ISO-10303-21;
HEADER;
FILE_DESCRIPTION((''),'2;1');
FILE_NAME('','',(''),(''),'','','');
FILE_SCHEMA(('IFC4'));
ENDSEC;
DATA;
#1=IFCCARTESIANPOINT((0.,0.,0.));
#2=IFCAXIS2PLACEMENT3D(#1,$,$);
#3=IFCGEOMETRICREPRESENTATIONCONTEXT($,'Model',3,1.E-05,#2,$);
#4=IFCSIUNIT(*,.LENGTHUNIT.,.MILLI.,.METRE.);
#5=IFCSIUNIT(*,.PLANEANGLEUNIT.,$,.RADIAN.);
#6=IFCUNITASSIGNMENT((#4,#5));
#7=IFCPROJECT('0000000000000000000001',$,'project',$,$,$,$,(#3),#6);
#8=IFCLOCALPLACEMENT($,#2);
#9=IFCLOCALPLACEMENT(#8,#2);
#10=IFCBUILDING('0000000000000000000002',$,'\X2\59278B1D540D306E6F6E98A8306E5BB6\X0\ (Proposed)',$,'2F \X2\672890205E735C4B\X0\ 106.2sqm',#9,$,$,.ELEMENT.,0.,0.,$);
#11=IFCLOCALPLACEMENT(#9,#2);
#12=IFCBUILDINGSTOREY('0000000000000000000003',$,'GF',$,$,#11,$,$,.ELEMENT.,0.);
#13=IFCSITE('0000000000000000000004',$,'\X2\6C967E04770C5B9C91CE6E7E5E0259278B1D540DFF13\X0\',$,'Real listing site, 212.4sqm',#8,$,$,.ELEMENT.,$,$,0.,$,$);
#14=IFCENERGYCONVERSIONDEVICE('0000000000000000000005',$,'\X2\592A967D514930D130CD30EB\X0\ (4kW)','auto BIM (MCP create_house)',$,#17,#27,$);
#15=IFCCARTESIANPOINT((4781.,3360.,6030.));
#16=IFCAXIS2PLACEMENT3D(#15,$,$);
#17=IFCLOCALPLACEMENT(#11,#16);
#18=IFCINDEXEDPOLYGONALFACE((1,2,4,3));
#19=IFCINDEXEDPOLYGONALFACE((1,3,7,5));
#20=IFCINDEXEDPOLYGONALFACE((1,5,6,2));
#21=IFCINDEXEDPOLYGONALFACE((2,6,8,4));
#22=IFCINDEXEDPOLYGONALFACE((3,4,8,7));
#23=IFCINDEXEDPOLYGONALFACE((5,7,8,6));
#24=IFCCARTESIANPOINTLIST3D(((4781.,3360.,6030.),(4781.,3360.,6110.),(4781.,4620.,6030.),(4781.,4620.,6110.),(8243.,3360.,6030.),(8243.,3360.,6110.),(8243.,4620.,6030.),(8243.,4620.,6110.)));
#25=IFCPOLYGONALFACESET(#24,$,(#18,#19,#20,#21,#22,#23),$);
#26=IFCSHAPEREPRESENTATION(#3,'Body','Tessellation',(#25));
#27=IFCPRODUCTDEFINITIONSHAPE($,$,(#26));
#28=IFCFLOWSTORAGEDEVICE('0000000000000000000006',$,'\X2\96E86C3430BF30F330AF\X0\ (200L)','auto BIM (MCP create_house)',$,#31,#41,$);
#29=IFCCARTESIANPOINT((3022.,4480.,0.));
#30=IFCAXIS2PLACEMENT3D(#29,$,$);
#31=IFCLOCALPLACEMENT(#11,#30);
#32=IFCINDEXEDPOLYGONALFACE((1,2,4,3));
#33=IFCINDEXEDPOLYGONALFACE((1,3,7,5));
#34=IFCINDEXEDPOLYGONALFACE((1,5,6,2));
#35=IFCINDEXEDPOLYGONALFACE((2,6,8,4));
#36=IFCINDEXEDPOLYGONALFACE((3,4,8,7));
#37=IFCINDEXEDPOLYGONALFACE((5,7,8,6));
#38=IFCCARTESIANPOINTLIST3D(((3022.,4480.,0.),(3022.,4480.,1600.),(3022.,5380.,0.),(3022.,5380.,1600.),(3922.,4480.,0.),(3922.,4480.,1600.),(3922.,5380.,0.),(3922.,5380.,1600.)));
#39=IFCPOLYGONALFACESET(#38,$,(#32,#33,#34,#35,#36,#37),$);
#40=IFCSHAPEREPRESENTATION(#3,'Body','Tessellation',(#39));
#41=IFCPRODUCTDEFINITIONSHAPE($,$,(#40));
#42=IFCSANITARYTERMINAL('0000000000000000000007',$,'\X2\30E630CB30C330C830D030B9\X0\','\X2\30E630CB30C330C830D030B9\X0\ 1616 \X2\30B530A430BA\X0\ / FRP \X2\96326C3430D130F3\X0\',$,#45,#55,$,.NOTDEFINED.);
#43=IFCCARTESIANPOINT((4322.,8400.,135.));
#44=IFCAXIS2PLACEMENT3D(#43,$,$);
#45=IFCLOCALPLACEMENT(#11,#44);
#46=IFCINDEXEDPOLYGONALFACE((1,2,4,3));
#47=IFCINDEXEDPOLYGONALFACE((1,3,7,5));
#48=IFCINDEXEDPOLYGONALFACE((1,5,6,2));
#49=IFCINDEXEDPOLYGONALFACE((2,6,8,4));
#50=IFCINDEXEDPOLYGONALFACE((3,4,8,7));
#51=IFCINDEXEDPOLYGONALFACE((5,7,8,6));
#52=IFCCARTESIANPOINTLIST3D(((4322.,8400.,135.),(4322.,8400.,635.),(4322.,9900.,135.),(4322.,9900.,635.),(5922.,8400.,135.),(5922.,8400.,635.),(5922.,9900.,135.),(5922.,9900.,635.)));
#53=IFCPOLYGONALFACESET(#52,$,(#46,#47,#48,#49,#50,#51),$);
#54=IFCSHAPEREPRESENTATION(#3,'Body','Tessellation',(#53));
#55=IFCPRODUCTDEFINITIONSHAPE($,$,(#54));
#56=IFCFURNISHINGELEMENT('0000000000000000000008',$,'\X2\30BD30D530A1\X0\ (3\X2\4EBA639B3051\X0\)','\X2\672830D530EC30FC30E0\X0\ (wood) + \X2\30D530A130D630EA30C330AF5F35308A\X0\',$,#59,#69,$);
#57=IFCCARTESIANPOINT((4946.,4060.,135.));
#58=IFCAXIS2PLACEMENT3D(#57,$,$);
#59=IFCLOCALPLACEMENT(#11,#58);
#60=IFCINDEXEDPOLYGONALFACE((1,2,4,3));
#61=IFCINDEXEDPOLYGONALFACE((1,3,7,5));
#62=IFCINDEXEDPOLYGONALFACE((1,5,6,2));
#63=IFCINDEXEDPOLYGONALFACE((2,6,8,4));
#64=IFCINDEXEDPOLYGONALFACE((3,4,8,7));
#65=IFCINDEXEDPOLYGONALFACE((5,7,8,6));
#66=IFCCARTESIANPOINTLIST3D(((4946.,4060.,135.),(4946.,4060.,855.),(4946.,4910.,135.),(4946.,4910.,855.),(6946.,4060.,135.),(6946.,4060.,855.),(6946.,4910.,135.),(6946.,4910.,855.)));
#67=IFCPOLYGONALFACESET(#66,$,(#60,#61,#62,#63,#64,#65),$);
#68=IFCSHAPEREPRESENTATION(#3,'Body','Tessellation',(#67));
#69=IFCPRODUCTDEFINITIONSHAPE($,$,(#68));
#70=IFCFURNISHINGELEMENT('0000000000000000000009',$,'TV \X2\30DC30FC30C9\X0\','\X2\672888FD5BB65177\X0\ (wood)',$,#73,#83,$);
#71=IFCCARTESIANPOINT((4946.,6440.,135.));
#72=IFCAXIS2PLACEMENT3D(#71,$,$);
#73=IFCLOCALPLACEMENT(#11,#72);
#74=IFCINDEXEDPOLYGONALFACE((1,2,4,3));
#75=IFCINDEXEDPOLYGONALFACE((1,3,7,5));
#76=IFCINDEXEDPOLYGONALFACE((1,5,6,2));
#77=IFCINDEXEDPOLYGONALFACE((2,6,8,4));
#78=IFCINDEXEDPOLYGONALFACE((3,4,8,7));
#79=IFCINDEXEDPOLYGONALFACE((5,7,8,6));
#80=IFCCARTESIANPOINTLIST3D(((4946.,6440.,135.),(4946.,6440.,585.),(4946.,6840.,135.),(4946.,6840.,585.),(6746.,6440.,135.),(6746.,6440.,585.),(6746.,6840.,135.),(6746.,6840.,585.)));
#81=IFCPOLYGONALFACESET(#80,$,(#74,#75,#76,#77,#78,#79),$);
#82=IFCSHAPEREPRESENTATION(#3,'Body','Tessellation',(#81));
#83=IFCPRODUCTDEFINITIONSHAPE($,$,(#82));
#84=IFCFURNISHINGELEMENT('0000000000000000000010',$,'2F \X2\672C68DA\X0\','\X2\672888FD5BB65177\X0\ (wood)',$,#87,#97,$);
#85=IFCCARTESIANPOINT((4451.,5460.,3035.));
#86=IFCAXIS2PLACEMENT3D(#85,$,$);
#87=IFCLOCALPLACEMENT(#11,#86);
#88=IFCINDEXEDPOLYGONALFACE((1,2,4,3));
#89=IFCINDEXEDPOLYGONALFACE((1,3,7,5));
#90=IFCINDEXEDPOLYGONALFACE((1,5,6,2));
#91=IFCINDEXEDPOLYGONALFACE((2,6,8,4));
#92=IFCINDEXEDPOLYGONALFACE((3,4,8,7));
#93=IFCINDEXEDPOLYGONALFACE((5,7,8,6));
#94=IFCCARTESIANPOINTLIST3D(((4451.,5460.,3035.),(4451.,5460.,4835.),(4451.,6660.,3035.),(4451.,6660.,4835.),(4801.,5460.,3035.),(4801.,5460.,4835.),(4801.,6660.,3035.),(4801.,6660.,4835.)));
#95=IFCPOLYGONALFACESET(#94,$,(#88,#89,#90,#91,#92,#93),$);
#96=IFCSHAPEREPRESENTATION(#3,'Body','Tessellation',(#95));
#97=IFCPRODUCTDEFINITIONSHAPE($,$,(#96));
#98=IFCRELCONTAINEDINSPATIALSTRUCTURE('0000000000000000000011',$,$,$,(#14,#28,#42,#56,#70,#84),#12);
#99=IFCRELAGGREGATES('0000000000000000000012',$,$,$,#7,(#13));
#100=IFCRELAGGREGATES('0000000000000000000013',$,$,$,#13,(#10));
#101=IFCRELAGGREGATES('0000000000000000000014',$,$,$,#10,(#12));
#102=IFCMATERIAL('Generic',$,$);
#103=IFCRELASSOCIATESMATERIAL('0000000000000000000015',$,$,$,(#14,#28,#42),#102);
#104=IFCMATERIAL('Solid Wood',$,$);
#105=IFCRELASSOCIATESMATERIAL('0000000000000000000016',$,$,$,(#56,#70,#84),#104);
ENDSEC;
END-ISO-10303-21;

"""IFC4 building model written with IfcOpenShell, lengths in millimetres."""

from ifc_helpers import new_model, si_unit, frame, frame_2d, origin, place, context, project, spatial, rectangle, extrude, material, element, save


model = new_model("IFC4")

# Units and contexts
model_context = context("Model", 3, precision=1e-05, world=origin())
ifc_project = project(units=[si_unit("LENGTHUNIT", "METRE", prefix="MILLI"), si_unit("PLANEANGLEUNIT", "RADIAN")], contexts=[model_context])

# Site, building, storey
site_placement = place(None, origin())
site = spatial("IfcSite", under=ifc_project, at=site_placement, Name="沖縄県宜野湾市大謝名３", ObjectType="Real listing site, 212.4sqm", CompositionType="ELEMENT", RefElevation=0.0)
building_placement = place(site_placement, origin())
building = spatial("IfcBuilding", under=site, at=building_placement, Name="大謝名の潮風の家 (Proposed)", ObjectType="2F 木造平屋 106.2sqm", CompositionType="ELEMENT", ElevationOfRefHeight=0.0, ElevationOfTerrain=0.0)
storey_placement = place(building_placement, origin())
storey = spatial("IfcBuildingStorey", under=building, at=storey_placement, Name="GF", CompositionType="ELEMENT", Elevation=0.0)

# Shared definitions
ifc_material_1 = material(Name="Solid Wood")

# Energy conversion device
ifc_material_2 = material(Name="Generic")
energy_conversion_device_placement = place(storey_placement, frame((4781.0, 3360.0, 6030.0)))
element("IfcEnergyConversionDevice", 1, at=energy_conversion_device_placement, inside=storey, material=ifc_material_2, Name="太陽光パネル (4kW)", Description="auto BIM (MCP create_house)", context=model_context, shape_type="SweptSolid", body=[
    extrude(rectangle(XDim=3462.0, YDim=1260.0, at=frame_2d((1731.0, 630.0))), frame((4781.0, 3360.0, 6030.0)), (0.0, 0.0, 1.0), 80.0),
])

# Flow storage device
flow_storage_device_placement = place(storey_placement, frame((3022.0, 4480.0, 0.0)))
element("IfcFlowStorageDevice", 2, at=flow_storage_device_placement, inside=storey, material=ifc_material_2, Name="雨水タンク (200L)", Description="auto BIM (MCP create_house)", context=model_context, shape_type="SweptSolid", body=[
    extrude(rectangle(XDim=900.0, YDim=900.0, at=frame_2d((450.0, 450.0))), frame((3022.0, 4480.0, 0.0)), (0.0, 0.0, 1.0), 1600.0),
])

# Sanitary terminal
sanitary_terminal_placement = place(storey_placement, frame((4322.0, 8400.0, 135.0)))
element("IfcSanitaryTerminal", 3, at=sanitary_terminal_placement, inside=storey, material=ifc_material_2, Name="ユニットバス", Description="ユニットバス 1616 サイズ / FRP 防水パン", PredefinedType="NOTDEFINED", context=model_context, shape_type="SweptSolid", body=[
    extrude(rectangle(XDim=1600.0, YDim=1500.0, at=frame_2d((800.0, 750.0))), frame((4322.0, 8400.0, 135.0)), (0.0, 0.0, 1.0), 500.0),
])

# Furnishing elements
furnishing_1_placement = place(storey_placement, frame((4946.0, 4060.0, 135.0)))
element("IfcFurnishingElement", 4, at=furnishing_1_placement, inside=storey, material=ifc_material_1, Name="ソファ (3人掛け)", Description="木フレーム (wood) + ファブリック張り", context=model_context, shape_type="SweptSolid", body=[
    extrude(rectangle(XDim=2000.0, YDim=850.0, at=frame_2d((1000.0, 425.0))), frame((4946.0, 4060.0, 135.0)), (0.0, 0.0, 1.0), 720.0),
])
furnishing_2_placement = place(storey_placement, frame((4946.0, 6440.0, 135.0)))
element("IfcFurnishingElement", 5, at=furnishing_2_placement, inside=storey, material=ifc_material_1, Name="TV ボード", Description="木製家具 (wood)", context=model_context, shape_type="SweptSolid", body=[
    extrude(rectangle(XDim=1800.0, YDim=400.0, at=frame_2d((900.0, 200.0))), frame((4946.0, 6440.0, 135.0)), (0.0, 0.0, 1.0), 450.0),
])
furnishing_3_placement = place(storey_placement, frame((4451.0, 5460.0, 3035.0)))
element("IfcFurnishingElement", 6, at=furnishing_3_placement, inside=storey, material=ifc_material_1, Name="2F 本棚", Description="木製家具 (wood)", context=model_context, shape_type="SweptSolid", body=[
    extrude(rectangle(XDim=350.0, YDim=1200.0, at=frame_2d((175.0, 600.0))), frame((4451.0, 5460.0, 3035.0)), (0.0, 0.0, 1.0), 1800.0),
])

save(model, "model.ifc")
